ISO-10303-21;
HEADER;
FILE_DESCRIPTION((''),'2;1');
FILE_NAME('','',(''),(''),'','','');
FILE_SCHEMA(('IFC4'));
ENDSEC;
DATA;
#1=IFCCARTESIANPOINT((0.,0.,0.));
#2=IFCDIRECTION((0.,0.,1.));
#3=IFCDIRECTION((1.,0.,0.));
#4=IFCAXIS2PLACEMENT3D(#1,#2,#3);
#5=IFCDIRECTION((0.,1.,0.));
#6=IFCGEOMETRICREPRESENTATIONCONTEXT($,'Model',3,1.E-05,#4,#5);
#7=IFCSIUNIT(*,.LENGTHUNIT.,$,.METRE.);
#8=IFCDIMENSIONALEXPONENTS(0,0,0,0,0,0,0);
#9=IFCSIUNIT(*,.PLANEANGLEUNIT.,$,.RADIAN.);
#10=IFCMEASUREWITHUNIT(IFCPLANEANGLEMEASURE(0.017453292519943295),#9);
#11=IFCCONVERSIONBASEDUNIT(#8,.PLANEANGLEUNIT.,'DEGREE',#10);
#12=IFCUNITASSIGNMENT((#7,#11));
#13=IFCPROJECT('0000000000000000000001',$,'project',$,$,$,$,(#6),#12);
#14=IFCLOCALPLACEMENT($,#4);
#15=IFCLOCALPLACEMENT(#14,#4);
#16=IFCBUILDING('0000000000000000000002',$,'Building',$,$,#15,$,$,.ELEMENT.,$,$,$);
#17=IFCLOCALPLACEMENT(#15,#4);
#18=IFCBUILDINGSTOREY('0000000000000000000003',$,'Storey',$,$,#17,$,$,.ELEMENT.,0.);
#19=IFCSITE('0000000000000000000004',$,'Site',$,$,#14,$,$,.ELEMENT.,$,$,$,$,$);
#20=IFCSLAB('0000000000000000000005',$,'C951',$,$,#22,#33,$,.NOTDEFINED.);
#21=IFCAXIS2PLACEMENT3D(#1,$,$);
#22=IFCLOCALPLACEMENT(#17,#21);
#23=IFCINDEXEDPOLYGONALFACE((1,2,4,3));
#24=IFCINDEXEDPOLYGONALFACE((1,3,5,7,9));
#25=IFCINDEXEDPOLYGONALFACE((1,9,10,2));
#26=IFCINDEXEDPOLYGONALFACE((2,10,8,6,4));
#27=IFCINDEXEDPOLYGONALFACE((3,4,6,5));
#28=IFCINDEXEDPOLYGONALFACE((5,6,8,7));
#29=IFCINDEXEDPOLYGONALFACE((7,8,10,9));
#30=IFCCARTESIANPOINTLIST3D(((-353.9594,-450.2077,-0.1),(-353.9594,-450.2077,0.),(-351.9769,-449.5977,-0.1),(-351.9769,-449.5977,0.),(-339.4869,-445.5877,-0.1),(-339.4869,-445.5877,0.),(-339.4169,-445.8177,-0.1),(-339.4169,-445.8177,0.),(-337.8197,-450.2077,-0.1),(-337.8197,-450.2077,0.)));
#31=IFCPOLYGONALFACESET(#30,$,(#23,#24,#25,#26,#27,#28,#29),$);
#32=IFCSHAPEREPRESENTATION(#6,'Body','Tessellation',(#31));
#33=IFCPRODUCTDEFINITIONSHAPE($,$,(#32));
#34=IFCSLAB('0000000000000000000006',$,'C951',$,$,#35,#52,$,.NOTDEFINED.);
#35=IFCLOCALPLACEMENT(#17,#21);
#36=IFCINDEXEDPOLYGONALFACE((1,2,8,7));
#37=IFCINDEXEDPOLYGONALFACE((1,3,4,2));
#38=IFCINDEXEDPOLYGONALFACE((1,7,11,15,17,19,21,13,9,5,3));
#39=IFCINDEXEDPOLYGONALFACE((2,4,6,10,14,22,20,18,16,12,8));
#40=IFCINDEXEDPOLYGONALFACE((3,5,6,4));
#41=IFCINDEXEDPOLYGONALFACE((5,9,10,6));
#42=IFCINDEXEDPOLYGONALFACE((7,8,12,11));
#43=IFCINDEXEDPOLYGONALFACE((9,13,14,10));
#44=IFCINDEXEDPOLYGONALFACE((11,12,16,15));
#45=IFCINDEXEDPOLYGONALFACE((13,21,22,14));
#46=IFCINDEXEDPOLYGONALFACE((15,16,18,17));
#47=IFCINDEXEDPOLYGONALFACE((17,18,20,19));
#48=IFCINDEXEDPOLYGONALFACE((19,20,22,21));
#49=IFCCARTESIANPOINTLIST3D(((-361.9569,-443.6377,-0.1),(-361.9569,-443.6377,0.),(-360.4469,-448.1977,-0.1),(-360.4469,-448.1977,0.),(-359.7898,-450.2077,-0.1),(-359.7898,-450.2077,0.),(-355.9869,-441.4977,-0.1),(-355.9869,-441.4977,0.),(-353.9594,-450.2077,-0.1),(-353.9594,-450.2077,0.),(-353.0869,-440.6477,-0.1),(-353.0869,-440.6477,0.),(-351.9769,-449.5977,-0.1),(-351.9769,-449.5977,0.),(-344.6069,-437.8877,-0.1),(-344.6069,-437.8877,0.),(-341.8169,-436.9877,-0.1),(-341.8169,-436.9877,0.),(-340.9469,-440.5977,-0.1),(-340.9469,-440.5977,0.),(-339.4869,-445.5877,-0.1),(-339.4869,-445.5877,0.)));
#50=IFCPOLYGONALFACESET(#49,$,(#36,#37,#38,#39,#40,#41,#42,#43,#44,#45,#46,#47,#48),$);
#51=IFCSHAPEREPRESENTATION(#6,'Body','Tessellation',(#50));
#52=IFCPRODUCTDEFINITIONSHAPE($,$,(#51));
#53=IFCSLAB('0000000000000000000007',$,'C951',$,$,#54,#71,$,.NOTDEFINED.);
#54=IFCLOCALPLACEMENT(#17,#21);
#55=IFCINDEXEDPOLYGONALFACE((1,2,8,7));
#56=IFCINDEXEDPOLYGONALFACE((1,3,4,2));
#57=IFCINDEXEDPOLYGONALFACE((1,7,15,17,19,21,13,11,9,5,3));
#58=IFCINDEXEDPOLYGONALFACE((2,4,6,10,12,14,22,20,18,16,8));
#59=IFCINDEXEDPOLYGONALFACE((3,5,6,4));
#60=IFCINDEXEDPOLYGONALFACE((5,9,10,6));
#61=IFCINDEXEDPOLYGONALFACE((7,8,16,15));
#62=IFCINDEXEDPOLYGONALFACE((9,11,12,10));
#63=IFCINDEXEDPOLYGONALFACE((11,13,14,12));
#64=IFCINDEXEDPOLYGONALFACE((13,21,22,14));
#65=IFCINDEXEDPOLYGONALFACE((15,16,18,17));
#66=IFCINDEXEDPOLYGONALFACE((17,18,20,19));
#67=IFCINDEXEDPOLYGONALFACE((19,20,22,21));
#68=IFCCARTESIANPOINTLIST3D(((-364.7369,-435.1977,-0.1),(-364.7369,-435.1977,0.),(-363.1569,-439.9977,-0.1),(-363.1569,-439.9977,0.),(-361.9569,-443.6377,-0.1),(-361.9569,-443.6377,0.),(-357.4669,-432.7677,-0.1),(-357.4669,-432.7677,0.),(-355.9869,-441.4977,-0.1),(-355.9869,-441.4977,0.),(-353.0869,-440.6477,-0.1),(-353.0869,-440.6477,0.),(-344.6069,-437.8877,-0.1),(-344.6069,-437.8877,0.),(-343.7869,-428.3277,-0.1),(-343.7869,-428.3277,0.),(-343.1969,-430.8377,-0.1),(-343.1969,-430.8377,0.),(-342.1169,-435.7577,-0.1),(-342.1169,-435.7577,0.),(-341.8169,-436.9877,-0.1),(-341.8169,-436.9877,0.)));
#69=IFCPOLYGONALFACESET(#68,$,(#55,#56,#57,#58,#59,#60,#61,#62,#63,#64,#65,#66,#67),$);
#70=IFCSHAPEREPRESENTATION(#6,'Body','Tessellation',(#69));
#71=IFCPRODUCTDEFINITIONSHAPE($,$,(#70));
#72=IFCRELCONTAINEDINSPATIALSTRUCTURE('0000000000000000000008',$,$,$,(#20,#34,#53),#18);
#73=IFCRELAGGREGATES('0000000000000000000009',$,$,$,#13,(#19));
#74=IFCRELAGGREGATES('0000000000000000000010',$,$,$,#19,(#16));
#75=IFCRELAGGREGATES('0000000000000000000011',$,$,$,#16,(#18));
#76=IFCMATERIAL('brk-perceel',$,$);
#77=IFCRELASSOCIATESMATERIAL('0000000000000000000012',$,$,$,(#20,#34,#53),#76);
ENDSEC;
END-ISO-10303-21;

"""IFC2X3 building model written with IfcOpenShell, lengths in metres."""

from ifc_helpers import new_model, entity, si_unit, converted_unit, direction, frame, origin_with_axes, place, context, project, spatial, polyline, outline, extrude, material, element, save


model = new_model("IFC2X3")

# Units and contexts
model_context = context("Model", 3, precision=1e-05, world=origin_with_axes(), true_north=direction((0.0, 1.0, 0.0)))
ifc_project = project(units=[si_unit("LENGTHUNIT", "METRE"), converted_unit("PLANEANGLEUNIT", "DEGREE", entity("IfcPlaneAngleMeasure", 0.017453292519943295), si_unit("PLANEANGLEUNIT", "RADIAN"), dimensions=[0, 0, 0, 0, 0, 0, 0])], contexts=[model_context])

# Site, building, storey
site_placement = place(None, origin_with_axes())
site = spatial("IfcSite", under=ifc_project, at=site_placement, Name="Site", CompositionType="ELEMENT")
building_placement = place(site_placement, origin_with_axes())
building = spatial("IfcBuilding", under=site, at=building_placement, Name="Building", CompositionType="ELEMENT")
storey_placement = place(building_placement, origin_with_axes())
storey = spatial("IfcBuildingStorey", under=building, at=storey_placement, Name="Storey", CompositionType="ELEMENT", Elevation=0.0)

# Slabs
ifc_material = material(Name="brk-perceel")
slab_1_placement = place(storey_placement, frame((0.0, 0.0, -0.1), z_axis=(0.0, 0.0, 1.0), x_axis=(1.0, 0.0, 0.0)))
element("IfcSlab", 1, at=slab_1_placement, inside=storey, material=ifc_material, Name="C951", PredefinedType="NOTDEFINED", context=model_context, shape_type="SweptSolid", body=[
    extrude(outline(polyline([(-351.9769, -449.5977), (-339.4869, -445.5877), (-339.4169, -445.8177), (-337.8197, -450.2077), (-353.9594, -450.2077), (-351.9769, -449.5977)])), origin_with_axes(), (0.0, 0.0, 1.0), 0.1),
])
slab_2_placement = place(storey_placement, frame((0.0, 0.0, -0.1), z_axis=(0.0, 0.0, 1.0), x_axis=(1.0, 0.0, 0.0)))
element("IfcSlab", 2, at=slab_2_placement, inside=storey, material=ifc_material, Name="C951", PredefinedType="NOTDEFINED", context=model_context, shape_type="SweptSolid", body=[
    extrude(outline(polyline([(-360.4469, -448.1977), (-361.9569, -443.6377), (-355.9869, -441.4977), (-353.0869, -440.6477), (-344.6069, -437.8877), (-341.8169, -436.9877), (-340.9469, -440.5977), (-339.4869, -445.5877), (-351.9769, -449.5977), (-353.9594, -450.2077), (-359.7898, -450.2077), (-360.4469, -448.1977)])), origin_with_axes(), (0.0, 0.0, 1.0), 0.1),
])
slab_3_placement = place(storey_placement, frame((0.0, 0.0, -0.1), z_axis=(0.0, 0.0, 1.0), x_axis=(1.0, 0.0, 0.0)))
element("IfcSlab", 3, at=slab_3_placement, inside=storey, material=ifc_material, Name="C951", PredefinedType="NOTDEFINED", context=model_context, shape_type="SweptSolid", body=[
    extrude(outline(polyline([(-364.7369, -435.1977), (-357.4669, -432.7677), (-343.7869, -428.3277), (-343.1969, -430.8377), (-342.1169, -435.7577), (-341.8169, -436.9877), (-344.6069, -437.8877), (-353.0869, -440.6477), (-355.9869, -441.4977), (-361.9569, -443.6377), (-363.1569, -439.9977), (-364.7369, -435.1977)])), origin_with_axes(), (0.0, 0.0, 1.0), 0.1),
])

save(model, "model.ifc")
